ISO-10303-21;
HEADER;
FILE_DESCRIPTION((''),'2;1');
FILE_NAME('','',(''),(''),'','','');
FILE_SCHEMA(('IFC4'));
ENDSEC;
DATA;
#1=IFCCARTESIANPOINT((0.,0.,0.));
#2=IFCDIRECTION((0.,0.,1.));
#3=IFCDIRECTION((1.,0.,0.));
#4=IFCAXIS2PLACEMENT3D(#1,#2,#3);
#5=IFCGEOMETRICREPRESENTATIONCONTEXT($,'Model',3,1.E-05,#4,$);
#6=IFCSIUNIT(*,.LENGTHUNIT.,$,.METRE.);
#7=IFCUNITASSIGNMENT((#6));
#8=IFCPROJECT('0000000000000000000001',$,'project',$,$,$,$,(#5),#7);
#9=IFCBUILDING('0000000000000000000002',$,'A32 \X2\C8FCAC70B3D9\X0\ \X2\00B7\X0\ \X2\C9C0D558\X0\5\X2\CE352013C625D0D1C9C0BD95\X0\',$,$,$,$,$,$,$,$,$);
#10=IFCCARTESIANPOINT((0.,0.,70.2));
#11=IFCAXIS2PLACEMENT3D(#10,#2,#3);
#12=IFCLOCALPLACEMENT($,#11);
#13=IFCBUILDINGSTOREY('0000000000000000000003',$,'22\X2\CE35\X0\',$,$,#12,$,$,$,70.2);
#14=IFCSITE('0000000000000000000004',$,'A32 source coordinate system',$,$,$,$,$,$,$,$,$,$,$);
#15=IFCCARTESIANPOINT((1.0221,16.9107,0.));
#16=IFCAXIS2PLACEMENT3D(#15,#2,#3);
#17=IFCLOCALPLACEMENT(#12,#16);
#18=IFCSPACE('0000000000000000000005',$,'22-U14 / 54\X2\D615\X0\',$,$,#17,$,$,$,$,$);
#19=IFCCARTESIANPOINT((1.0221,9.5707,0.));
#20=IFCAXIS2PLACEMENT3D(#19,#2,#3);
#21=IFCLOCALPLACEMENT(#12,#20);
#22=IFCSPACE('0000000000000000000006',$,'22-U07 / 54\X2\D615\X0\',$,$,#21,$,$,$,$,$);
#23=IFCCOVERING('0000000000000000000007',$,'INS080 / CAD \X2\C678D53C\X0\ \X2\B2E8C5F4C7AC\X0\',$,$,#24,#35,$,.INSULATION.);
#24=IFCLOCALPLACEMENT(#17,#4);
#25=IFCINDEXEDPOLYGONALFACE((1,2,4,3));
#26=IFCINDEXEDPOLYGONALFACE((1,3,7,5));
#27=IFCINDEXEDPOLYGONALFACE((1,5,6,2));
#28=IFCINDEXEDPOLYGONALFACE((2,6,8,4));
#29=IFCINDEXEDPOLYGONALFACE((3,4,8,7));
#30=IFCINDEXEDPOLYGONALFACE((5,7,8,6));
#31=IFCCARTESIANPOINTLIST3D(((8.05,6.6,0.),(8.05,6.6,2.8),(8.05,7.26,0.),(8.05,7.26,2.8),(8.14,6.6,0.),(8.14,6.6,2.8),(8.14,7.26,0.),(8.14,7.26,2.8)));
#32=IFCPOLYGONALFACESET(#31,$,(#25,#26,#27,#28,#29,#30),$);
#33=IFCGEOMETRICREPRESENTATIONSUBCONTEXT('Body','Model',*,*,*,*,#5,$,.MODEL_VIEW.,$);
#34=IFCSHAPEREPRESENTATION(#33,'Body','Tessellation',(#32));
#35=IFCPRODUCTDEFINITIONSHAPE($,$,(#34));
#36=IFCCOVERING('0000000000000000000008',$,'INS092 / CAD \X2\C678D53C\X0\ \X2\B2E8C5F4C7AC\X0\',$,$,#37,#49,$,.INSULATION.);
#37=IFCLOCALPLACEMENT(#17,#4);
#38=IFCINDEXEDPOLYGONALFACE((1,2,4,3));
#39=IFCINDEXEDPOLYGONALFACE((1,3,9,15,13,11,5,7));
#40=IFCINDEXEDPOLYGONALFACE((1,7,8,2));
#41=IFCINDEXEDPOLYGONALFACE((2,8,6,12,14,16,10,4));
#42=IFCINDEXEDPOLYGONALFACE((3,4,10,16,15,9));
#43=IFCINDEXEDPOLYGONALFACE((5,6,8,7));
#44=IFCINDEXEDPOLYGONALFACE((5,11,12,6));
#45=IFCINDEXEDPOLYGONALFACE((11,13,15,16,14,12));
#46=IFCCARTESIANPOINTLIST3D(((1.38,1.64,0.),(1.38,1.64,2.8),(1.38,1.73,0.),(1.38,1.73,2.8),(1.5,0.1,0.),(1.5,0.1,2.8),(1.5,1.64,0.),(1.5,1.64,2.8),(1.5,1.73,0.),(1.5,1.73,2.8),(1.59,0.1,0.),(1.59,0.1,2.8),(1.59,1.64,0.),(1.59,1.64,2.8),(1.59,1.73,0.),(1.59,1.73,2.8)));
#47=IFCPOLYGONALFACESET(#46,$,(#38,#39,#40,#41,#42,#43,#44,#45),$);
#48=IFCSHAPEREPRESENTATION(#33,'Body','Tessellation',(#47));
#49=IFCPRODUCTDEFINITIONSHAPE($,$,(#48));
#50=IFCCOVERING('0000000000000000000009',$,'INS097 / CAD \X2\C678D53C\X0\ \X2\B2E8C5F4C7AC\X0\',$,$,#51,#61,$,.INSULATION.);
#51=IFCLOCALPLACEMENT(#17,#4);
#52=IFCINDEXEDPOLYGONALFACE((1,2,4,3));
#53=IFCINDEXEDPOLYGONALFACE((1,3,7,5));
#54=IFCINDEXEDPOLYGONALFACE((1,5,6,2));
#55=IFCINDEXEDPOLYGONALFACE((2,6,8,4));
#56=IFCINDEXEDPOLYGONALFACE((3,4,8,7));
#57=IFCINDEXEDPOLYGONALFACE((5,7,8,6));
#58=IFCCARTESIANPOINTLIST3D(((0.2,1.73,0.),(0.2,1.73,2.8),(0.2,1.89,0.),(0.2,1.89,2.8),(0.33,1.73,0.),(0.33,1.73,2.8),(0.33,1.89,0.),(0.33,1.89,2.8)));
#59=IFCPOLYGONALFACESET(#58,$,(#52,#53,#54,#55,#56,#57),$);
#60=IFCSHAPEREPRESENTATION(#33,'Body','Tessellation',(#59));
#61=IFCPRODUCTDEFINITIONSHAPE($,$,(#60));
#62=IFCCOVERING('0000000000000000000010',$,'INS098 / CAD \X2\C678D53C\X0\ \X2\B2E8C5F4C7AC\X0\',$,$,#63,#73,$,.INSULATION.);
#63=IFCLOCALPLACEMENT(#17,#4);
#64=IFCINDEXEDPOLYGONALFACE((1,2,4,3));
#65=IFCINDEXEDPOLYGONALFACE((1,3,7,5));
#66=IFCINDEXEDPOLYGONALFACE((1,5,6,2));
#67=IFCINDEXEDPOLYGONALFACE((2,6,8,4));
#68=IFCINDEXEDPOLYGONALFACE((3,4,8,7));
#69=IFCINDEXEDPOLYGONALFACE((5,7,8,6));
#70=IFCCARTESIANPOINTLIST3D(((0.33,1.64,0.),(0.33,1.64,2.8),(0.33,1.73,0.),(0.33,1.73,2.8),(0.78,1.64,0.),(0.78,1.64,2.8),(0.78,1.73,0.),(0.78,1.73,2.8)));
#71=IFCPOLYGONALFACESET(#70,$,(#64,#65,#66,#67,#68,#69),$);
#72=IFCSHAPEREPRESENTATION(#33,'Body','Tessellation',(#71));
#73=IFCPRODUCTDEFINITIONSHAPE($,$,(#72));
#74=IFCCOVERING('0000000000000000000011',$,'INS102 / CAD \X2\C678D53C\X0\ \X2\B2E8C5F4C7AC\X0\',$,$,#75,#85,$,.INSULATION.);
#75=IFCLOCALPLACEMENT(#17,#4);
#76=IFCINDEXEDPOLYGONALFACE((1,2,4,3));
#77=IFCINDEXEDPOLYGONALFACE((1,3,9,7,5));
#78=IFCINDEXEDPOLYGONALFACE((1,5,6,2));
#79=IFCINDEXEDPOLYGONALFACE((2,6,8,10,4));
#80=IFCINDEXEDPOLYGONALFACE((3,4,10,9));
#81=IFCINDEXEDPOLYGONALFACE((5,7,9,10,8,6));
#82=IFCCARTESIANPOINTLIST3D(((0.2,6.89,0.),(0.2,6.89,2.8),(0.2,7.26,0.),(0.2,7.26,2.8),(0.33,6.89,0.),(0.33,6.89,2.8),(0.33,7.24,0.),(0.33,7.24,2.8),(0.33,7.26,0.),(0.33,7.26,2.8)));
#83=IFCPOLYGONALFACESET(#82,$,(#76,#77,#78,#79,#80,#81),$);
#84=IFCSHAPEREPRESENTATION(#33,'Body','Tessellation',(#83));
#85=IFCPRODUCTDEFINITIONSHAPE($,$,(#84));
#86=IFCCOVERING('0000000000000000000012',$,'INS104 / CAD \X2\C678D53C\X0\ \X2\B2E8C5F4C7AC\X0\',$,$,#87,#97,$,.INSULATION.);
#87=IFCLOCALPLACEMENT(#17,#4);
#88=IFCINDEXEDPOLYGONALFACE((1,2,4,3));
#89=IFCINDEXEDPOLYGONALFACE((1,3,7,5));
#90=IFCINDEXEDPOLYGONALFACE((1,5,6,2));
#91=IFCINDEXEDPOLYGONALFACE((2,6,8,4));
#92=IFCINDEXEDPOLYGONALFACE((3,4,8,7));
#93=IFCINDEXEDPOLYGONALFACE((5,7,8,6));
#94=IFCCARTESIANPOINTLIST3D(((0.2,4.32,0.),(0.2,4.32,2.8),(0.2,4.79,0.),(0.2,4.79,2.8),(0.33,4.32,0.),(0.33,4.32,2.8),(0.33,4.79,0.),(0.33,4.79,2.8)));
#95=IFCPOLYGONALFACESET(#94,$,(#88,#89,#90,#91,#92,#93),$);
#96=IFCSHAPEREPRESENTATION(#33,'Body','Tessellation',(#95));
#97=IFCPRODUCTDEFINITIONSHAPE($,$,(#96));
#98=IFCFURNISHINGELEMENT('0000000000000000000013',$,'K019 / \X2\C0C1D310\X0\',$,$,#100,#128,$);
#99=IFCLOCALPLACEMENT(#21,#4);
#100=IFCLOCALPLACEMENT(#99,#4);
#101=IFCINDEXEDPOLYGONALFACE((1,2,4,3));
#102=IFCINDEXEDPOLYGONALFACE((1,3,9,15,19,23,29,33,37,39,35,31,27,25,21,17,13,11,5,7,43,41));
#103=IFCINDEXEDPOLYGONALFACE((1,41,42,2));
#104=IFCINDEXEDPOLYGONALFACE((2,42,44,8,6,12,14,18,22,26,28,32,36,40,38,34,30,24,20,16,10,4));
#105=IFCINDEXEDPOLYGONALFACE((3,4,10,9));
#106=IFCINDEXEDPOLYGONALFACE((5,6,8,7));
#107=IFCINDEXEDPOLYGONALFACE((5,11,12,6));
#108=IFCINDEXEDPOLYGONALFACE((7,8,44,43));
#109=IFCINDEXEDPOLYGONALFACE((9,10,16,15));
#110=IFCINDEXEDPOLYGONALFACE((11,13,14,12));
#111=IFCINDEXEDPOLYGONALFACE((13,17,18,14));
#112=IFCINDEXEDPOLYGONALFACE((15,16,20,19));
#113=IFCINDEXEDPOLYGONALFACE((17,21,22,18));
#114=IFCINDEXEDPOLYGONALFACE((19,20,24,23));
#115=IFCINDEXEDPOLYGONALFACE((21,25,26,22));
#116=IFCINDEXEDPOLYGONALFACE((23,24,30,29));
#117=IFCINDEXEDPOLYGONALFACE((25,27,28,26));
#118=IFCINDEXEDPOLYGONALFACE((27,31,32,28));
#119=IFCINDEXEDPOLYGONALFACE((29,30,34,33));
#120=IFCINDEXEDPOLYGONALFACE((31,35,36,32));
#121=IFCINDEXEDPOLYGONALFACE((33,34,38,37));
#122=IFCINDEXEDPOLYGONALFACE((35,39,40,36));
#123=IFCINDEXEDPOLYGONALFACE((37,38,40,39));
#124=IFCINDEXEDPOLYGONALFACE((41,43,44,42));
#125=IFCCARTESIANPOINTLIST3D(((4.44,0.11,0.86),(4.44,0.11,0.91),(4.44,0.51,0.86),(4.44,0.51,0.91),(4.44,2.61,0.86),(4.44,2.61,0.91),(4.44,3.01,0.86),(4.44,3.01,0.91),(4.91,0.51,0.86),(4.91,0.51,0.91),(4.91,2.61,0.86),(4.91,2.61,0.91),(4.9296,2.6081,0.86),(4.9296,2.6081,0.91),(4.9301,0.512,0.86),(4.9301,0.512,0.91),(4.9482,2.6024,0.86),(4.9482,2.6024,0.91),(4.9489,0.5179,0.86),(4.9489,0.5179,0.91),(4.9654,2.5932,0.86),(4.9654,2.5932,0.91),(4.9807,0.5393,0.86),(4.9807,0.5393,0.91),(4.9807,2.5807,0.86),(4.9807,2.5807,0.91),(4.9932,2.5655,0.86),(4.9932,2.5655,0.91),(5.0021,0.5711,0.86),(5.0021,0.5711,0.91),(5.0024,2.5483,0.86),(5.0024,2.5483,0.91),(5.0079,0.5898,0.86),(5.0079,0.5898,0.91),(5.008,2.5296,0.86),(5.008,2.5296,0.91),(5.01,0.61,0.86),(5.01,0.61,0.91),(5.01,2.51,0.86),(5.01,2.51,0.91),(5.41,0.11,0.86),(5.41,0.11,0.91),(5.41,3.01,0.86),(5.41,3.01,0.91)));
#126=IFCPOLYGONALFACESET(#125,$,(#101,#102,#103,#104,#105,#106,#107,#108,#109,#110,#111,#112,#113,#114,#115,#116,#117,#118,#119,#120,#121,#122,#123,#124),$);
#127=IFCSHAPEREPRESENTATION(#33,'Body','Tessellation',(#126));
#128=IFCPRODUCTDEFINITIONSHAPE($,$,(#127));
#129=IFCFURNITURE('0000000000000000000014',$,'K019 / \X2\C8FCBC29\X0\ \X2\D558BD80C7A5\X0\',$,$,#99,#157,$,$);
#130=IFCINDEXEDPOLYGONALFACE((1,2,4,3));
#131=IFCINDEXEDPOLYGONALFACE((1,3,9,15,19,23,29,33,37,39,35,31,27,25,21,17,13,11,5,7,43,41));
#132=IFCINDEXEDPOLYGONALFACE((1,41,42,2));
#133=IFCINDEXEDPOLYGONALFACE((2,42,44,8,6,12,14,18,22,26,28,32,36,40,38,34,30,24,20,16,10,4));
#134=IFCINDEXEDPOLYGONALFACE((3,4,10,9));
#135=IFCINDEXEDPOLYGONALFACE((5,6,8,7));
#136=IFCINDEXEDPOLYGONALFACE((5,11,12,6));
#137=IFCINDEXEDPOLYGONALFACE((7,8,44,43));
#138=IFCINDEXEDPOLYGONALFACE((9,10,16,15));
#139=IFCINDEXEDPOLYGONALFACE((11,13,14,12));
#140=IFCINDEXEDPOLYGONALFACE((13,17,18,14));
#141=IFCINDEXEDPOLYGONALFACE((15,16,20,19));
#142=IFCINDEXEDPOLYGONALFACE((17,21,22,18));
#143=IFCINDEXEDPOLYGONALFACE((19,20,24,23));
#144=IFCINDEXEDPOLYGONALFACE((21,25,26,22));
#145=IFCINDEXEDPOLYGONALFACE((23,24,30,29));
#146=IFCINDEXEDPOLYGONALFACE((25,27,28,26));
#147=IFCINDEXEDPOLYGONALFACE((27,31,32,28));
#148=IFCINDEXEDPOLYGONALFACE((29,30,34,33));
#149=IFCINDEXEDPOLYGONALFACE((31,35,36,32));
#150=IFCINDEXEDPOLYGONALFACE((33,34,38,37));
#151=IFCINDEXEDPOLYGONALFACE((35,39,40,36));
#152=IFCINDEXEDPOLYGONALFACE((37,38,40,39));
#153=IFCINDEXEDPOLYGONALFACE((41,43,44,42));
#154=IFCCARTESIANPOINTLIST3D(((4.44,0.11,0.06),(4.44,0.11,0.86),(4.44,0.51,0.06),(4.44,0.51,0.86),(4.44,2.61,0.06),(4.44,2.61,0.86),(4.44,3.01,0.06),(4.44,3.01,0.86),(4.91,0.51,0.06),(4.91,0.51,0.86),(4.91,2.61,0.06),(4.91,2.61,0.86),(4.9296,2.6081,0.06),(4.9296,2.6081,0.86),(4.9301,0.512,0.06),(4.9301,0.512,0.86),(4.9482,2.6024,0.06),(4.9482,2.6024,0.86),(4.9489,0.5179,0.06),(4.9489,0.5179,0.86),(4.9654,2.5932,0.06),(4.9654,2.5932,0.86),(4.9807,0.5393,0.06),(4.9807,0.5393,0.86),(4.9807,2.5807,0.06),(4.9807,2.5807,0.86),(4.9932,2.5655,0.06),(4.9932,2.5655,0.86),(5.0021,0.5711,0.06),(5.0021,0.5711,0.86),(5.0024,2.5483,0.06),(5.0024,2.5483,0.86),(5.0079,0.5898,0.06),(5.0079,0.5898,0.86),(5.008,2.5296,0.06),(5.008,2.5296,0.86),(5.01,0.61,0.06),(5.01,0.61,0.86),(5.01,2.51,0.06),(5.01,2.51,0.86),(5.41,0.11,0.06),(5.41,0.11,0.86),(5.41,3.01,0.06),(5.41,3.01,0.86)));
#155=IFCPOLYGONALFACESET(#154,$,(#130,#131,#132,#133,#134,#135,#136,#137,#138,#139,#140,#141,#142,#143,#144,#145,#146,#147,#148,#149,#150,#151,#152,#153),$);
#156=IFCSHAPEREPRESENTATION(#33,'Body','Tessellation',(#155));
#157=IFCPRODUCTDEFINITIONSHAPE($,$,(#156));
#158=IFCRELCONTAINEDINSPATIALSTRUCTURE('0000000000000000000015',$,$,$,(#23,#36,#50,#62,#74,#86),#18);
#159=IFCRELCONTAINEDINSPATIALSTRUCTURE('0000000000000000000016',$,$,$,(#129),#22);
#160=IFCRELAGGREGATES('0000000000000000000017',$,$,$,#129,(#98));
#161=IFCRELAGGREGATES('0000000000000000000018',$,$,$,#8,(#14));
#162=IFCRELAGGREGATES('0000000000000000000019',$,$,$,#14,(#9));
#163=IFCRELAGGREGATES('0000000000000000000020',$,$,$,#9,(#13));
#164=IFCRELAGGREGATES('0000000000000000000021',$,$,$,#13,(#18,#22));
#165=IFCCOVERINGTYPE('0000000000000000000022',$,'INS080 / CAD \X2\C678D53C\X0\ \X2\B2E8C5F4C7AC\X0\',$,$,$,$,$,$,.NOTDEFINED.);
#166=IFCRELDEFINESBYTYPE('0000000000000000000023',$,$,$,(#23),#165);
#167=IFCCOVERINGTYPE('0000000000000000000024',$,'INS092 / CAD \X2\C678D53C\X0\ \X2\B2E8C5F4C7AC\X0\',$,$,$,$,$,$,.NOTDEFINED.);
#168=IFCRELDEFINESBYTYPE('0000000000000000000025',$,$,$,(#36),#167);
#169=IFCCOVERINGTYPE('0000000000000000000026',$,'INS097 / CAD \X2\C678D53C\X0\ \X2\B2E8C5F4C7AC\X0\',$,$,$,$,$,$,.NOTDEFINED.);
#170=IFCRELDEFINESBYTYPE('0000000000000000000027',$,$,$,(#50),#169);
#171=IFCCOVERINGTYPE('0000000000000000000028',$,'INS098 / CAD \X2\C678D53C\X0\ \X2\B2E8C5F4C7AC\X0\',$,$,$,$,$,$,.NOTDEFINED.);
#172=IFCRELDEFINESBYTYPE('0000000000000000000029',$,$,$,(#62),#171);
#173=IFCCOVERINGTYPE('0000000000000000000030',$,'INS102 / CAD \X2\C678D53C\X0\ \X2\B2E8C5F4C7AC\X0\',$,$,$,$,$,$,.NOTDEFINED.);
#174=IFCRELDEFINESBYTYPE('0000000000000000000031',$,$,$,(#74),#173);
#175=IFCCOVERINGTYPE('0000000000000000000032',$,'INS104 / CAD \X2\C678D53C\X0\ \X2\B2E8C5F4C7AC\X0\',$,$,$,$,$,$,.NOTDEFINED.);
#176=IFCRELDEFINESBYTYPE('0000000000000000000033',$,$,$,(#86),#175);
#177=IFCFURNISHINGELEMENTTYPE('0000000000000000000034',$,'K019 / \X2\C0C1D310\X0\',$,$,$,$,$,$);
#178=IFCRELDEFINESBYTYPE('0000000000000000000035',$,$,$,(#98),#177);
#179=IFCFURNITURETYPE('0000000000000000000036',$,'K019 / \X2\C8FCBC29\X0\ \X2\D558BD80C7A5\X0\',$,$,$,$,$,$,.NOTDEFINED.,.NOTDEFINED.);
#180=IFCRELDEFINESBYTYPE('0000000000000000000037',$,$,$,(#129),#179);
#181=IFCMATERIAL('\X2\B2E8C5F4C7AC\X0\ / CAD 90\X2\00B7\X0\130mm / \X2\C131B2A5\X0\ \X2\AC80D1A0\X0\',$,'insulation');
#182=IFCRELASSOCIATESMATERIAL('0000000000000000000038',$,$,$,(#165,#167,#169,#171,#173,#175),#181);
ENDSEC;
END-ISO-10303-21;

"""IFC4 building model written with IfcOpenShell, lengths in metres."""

from ifc_helpers import new_model, si_unit, frame, origin, origin_with_axes, place, context, subcontext, project, spatial, polyline, outline, extrude, source, transform, mapped, material, type_object, type_shapes, element, aggregate, save


model = new_model("IFC4")

# Units and contexts
model_context = context("Model", 3, precision=1e-05, world=origin_with_axes())
body_context = subcontext(model_context, "Body", "Model", "MODEL_VIEW")
ifc_project = project(units=[si_unit("LENGTHUNIT", "METRE")], contexts=[model_context])

# Site, building, storey, space
storey_placement = place(None, frame((0.0, 0.0, 70.2), z_axis=(0.0, 0.0, 1.0), x_axis=(1.0, 0.0, 0.0)))
space_1_placement = place(storey_placement, frame((1.0221, 16.9107, 0.0), z_axis=(0.0, 0.0, 1.0), x_axis=(1.0, 0.0, 0.0)))
site = spatial("IfcSite", under=ifc_project, Name="A32 source coordinate system")
building = spatial("IfcBuilding", under=site, Name="A32 주거동 · 지하5층–옥탑지붕")
storey = spatial("IfcBuildingStorey", under=building, at=storey_placement, Name="22층", Elevation=70.2)
space_1 = spatial("IfcSpace", under=storey, at=space_1_placement, Name="22-U14 / 54형")

# Coverings
ifc_material = material(Name="단열재 / CAD 90·130mm / 성능 검토", Category="insulation")
covering_type_1 = type_object("IfcCoveringType", Name="INS080 / CAD 외피 단열재", PredefinedType="NOTDEFINED", material=ifc_material)
shared_shape_1 = source(origin(), body_context, "Body", "SweptSolid", [
    extrude(outline(polyline([(8.14, 7.26), (8.14, 6.6), (8.05, 6.6), (8.05, 7.26), (8.14, 7.26)])), origin(), (0.0, 0.0, 1.0), 2.8),
])
type_shapes(covering_type_1, [shared_shape_1])
covering_1_placement = place(space_1_placement, origin_with_axes())
element("IfcCovering", 1, at=covering_1_placement, inside=space_1, type_object=covering_type_1, Name="INS080 / CAD 외피 단열재", PredefinedType="INSULATION", context=body_context, shape_type="MappedRepresentation", body=[
    mapped(shared_shape_1, transform((0.0, 0.0, 0.0), scale=1.0)),
])
covering_type_2 = type_object("IfcCoveringType", Name="INS092 / CAD 외피 단열재", PredefinedType="NOTDEFINED", material=ifc_material)
shared_shape_2 = source(origin(), body_context, "Body", "SweptSolid", [
    extrude(outline(polyline([(1.59, 1.73), (1.59, 1.64), (1.59, 0.1), (1.5, 0.1), (1.5, 1.64), (1.38, 1.64), (1.38, 1.73), (1.5, 1.73), (1.59, 1.73)])), origin(), (0.0, 0.0, 1.0), 2.8),
])
type_shapes(covering_type_2, [shared_shape_2])
covering_2_placement = place(space_1_placement, origin_with_axes())
element("IfcCovering", 2, at=covering_2_placement, inside=space_1, type_object=covering_type_2, Name="INS092 / CAD 외피 단열재", PredefinedType="INSULATION", context=body_context, shape_type="MappedRepresentation", body=[
    mapped(shared_shape_2, transform((0.0, 0.0, 0.0), scale=1.0)),
])
covering_type_3 = type_object("IfcCoveringType", Name="INS097 / CAD 외피 단열재", PredefinedType="NOTDEFINED", material=ifc_material)
shared_shape_3 = source(origin(), body_context, "Body", "SweptSolid", [
    extrude(outline(polyline([(0.33, 1.89), (0.33, 1.73), (0.2, 1.73), (0.2, 1.89), (0.33, 1.89)])), origin(), (0.0, 0.0, 1.0), 2.8),
])
type_shapes(covering_type_3, [shared_shape_3])
covering_3_placement = place(space_1_placement, origin_with_axes())
element("IfcCovering", 3, at=covering_3_placement, inside=space_1, type_object=covering_type_3, Name="INS097 / CAD 외피 단열재", PredefinedType="INSULATION", context=body_context, shape_type="MappedRepresentation", body=[
    mapped(shared_shape_3, transform((0.0, 0.0, 0.0), scale=1.0)),
])
covering_type_4 = type_object("IfcCoveringType", Name="INS098 / CAD 외피 단열재", PredefinedType="NOTDEFINED", material=ifc_material)
shared_shape_4 = source(origin(), body_context, "Body", "SweptSolid", [
    extrude(outline(polyline([(0.78, 1.73), (0.78, 1.64), (0.33, 1.64), (0.33, 1.73), (0.78, 1.73)])), origin(), (0.0, 0.0, 1.0), 2.8),
])
type_shapes(covering_type_4, [shared_shape_4])
covering_4_placement = place(space_1_placement, origin_with_axes())
element("IfcCovering", 4, at=covering_4_placement, inside=space_1, type_object=covering_type_4, Name="INS098 / CAD 외피 단열재", PredefinedType="INSULATION", context=body_context, shape_type="MappedRepresentation", body=[
    mapped(shared_shape_4, transform((0.0, 0.0, 0.0), scale=1.0)),
])
covering_type_5 = type_object("IfcCoveringType", Name="INS102 / CAD 외피 단열재", PredefinedType="NOTDEFINED", material=ifc_material)
shared_shape_5 = source(origin(), body_context, "Body", "SweptSolid", [
    extrude(outline(polyline([(0.33, 7.26), (0.33, 7.24), (0.33, 6.89), (0.2, 6.89), (0.2, 7.26), (0.33, 7.26)])), origin(), (0.0, 0.0, 1.0), 2.8),
])
type_shapes(covering_type_5, [shared_shape_5])
covering_5_placement = place(space_1_placement, origin_with_axes())
element("IfcCovering", 5, at=covering_5_placement, inside=space_1, type_object=covering_type_5, Name="INS102 / CAD 외피 단열재", PredefinedType="INSULATION", context=body_context, shape_type="MappedRepresentation", body=[
    mapped(shared_shape_5, transform((0.0, 0.0, 0.0), scale=1.0)),
])
covering_type_6 = type_object("IfcCoveringType", Name="INS104 / CAD 외피 단열재", PredefinedType="NOTDEFINED", material=ifc_material)
shared_shape_6 = source(origin(), body_context, "Body", "SweptSolid", [
    extrude(outline(polyline([(0.33, 4.32), (0.2, 4.32), (0.2, 4.79), (0.33, 4.79), (0.33, 4.32)])), origin(), (0.0, 0.0, 1.0), 2.8),
])
type_shapes(covering_type_6, [shared_shape_6])
covering_6_placement = place(space_1_placement, origin_with_axes())
element("IfcCovering", 6, at=covering_6_placement, inside=space_1, type_object=covering_type_6, Name="INS104 / CAD 외피 단열재", PredefinedType="INSULATION", context=body_context, shape_type="MappedRepresentation", body=[
    mapped(shared_shape_6, transform((0.0, 0.0, 0.0), scale=1.0)),
])

# Furnishing element
furnishing_element_type = type_object("IfcFurnishingElementType", Name="K019 / 상판")
shared_shape_7 = source(origin(), body_context, "Body", "SweptSolid", [
    extrude(outline(polyline([(4.91, 0.51), (4.9301, 0.512), (4.9489, 0.5179), (4.9807, 0.5393), (5.0021, 0.5711), (5.0079, 0.5898), (5.01, 0.61), (5.01, 2.51), (5.008, 2.5296), (5.0024, 2.5483), (4.9932, 2.5655), (4.9807, 2.5807), (4.9654, 2.5932), (4.9482, 2.6024), (4.9296, 2.6081), (4.91, 2.61), (4.44, 2.61), (4.44, 3.01), (5.41, 3.01), (5.41, 0.11), (4.44, 0.11), (4.44, 0.51), (4.91, 0.51)])), frame((0.0, 0.0, 0.86)), (0.0, 0.0, 1.0), 0.05),
])
type_shapes(furnishing_element_type, [shared_shape_7])
space_2_placement = place(storey_placement, frame((1.0221, 9.5707, 0.0), z_axis=(0.0, 0.0, 1.0), x_axis=(1.0, 0.0, 0.0)))
furniture_placement = place(space_2_placement, origin_with_axes())
furnishing_placement = place(furniture_placement, origin_with_axes())
furnishing = element("IfcFurnishingElement", 7, at=furnishing_placement, type_object=furnishing_element_type, Name="K019 / 상판", context=body_context, shape_type="MappedRepresentation", body=[
    mapped(shared_shape_7, transform((0.0, 0.0, 0.0), scale=1.0)),
])

# Shared definitions
space_2 = spatial("IfcSpace", under=storey, at=space_2_placement, Name="22-U07 / 54형")

# Furniture
furniture_type = type_object("IfcFurnitureType", Name="K019 / 주방 하부장", AssemblyPlace="NOTDEFINED", PredefinedType="NOTDEFINED")
shared_shape_8 = source(origin(), body_context, "Body", "SweptSolid", [
    extrude(outline(polyline([(4.44, 0.51), (4.91, 0.51), (4.9301, 0.512), (4.9489, 0.5179), (4.9807, 0.5393), (5.0021, 0.5711), (5.0079, 0.5898), (5.01, 0.61), (5.01, 2.51), (5.008, 2.5296), (5.0024, 2.5483), (4.9932, 2.5655), (4.9807, 2.5807), (4.9654, 2.5932), (4.9482, 2.6024), (4.9296, 2.6081), (4.91, 2.61), (4.44, 2.61), (4.44, 3.01), (5.41, 3.01), (5.41, 0.11), (4.44, 0.11), (4.44, 0.51)])), frame((0.0, 0.0, 0.06)), (0.0, 0.0, 1.0), 0.8),
])
type_shapes(furniture_type, [shared_shape_8])
furniture = element("IfcFurniture", 8, at=furniture_placement, inside=space_2, type_object=furniture_type, Name="K019 / 주방 하부장", context=body_context, shape_type="MappedRepresentation", body=[
    mapped(shared_shape_8, transform((0.0, 0.0, 0.0), scale=1.0)),
])
aggregate(furniture, [furnishing])

save(model, "model.ifc")
